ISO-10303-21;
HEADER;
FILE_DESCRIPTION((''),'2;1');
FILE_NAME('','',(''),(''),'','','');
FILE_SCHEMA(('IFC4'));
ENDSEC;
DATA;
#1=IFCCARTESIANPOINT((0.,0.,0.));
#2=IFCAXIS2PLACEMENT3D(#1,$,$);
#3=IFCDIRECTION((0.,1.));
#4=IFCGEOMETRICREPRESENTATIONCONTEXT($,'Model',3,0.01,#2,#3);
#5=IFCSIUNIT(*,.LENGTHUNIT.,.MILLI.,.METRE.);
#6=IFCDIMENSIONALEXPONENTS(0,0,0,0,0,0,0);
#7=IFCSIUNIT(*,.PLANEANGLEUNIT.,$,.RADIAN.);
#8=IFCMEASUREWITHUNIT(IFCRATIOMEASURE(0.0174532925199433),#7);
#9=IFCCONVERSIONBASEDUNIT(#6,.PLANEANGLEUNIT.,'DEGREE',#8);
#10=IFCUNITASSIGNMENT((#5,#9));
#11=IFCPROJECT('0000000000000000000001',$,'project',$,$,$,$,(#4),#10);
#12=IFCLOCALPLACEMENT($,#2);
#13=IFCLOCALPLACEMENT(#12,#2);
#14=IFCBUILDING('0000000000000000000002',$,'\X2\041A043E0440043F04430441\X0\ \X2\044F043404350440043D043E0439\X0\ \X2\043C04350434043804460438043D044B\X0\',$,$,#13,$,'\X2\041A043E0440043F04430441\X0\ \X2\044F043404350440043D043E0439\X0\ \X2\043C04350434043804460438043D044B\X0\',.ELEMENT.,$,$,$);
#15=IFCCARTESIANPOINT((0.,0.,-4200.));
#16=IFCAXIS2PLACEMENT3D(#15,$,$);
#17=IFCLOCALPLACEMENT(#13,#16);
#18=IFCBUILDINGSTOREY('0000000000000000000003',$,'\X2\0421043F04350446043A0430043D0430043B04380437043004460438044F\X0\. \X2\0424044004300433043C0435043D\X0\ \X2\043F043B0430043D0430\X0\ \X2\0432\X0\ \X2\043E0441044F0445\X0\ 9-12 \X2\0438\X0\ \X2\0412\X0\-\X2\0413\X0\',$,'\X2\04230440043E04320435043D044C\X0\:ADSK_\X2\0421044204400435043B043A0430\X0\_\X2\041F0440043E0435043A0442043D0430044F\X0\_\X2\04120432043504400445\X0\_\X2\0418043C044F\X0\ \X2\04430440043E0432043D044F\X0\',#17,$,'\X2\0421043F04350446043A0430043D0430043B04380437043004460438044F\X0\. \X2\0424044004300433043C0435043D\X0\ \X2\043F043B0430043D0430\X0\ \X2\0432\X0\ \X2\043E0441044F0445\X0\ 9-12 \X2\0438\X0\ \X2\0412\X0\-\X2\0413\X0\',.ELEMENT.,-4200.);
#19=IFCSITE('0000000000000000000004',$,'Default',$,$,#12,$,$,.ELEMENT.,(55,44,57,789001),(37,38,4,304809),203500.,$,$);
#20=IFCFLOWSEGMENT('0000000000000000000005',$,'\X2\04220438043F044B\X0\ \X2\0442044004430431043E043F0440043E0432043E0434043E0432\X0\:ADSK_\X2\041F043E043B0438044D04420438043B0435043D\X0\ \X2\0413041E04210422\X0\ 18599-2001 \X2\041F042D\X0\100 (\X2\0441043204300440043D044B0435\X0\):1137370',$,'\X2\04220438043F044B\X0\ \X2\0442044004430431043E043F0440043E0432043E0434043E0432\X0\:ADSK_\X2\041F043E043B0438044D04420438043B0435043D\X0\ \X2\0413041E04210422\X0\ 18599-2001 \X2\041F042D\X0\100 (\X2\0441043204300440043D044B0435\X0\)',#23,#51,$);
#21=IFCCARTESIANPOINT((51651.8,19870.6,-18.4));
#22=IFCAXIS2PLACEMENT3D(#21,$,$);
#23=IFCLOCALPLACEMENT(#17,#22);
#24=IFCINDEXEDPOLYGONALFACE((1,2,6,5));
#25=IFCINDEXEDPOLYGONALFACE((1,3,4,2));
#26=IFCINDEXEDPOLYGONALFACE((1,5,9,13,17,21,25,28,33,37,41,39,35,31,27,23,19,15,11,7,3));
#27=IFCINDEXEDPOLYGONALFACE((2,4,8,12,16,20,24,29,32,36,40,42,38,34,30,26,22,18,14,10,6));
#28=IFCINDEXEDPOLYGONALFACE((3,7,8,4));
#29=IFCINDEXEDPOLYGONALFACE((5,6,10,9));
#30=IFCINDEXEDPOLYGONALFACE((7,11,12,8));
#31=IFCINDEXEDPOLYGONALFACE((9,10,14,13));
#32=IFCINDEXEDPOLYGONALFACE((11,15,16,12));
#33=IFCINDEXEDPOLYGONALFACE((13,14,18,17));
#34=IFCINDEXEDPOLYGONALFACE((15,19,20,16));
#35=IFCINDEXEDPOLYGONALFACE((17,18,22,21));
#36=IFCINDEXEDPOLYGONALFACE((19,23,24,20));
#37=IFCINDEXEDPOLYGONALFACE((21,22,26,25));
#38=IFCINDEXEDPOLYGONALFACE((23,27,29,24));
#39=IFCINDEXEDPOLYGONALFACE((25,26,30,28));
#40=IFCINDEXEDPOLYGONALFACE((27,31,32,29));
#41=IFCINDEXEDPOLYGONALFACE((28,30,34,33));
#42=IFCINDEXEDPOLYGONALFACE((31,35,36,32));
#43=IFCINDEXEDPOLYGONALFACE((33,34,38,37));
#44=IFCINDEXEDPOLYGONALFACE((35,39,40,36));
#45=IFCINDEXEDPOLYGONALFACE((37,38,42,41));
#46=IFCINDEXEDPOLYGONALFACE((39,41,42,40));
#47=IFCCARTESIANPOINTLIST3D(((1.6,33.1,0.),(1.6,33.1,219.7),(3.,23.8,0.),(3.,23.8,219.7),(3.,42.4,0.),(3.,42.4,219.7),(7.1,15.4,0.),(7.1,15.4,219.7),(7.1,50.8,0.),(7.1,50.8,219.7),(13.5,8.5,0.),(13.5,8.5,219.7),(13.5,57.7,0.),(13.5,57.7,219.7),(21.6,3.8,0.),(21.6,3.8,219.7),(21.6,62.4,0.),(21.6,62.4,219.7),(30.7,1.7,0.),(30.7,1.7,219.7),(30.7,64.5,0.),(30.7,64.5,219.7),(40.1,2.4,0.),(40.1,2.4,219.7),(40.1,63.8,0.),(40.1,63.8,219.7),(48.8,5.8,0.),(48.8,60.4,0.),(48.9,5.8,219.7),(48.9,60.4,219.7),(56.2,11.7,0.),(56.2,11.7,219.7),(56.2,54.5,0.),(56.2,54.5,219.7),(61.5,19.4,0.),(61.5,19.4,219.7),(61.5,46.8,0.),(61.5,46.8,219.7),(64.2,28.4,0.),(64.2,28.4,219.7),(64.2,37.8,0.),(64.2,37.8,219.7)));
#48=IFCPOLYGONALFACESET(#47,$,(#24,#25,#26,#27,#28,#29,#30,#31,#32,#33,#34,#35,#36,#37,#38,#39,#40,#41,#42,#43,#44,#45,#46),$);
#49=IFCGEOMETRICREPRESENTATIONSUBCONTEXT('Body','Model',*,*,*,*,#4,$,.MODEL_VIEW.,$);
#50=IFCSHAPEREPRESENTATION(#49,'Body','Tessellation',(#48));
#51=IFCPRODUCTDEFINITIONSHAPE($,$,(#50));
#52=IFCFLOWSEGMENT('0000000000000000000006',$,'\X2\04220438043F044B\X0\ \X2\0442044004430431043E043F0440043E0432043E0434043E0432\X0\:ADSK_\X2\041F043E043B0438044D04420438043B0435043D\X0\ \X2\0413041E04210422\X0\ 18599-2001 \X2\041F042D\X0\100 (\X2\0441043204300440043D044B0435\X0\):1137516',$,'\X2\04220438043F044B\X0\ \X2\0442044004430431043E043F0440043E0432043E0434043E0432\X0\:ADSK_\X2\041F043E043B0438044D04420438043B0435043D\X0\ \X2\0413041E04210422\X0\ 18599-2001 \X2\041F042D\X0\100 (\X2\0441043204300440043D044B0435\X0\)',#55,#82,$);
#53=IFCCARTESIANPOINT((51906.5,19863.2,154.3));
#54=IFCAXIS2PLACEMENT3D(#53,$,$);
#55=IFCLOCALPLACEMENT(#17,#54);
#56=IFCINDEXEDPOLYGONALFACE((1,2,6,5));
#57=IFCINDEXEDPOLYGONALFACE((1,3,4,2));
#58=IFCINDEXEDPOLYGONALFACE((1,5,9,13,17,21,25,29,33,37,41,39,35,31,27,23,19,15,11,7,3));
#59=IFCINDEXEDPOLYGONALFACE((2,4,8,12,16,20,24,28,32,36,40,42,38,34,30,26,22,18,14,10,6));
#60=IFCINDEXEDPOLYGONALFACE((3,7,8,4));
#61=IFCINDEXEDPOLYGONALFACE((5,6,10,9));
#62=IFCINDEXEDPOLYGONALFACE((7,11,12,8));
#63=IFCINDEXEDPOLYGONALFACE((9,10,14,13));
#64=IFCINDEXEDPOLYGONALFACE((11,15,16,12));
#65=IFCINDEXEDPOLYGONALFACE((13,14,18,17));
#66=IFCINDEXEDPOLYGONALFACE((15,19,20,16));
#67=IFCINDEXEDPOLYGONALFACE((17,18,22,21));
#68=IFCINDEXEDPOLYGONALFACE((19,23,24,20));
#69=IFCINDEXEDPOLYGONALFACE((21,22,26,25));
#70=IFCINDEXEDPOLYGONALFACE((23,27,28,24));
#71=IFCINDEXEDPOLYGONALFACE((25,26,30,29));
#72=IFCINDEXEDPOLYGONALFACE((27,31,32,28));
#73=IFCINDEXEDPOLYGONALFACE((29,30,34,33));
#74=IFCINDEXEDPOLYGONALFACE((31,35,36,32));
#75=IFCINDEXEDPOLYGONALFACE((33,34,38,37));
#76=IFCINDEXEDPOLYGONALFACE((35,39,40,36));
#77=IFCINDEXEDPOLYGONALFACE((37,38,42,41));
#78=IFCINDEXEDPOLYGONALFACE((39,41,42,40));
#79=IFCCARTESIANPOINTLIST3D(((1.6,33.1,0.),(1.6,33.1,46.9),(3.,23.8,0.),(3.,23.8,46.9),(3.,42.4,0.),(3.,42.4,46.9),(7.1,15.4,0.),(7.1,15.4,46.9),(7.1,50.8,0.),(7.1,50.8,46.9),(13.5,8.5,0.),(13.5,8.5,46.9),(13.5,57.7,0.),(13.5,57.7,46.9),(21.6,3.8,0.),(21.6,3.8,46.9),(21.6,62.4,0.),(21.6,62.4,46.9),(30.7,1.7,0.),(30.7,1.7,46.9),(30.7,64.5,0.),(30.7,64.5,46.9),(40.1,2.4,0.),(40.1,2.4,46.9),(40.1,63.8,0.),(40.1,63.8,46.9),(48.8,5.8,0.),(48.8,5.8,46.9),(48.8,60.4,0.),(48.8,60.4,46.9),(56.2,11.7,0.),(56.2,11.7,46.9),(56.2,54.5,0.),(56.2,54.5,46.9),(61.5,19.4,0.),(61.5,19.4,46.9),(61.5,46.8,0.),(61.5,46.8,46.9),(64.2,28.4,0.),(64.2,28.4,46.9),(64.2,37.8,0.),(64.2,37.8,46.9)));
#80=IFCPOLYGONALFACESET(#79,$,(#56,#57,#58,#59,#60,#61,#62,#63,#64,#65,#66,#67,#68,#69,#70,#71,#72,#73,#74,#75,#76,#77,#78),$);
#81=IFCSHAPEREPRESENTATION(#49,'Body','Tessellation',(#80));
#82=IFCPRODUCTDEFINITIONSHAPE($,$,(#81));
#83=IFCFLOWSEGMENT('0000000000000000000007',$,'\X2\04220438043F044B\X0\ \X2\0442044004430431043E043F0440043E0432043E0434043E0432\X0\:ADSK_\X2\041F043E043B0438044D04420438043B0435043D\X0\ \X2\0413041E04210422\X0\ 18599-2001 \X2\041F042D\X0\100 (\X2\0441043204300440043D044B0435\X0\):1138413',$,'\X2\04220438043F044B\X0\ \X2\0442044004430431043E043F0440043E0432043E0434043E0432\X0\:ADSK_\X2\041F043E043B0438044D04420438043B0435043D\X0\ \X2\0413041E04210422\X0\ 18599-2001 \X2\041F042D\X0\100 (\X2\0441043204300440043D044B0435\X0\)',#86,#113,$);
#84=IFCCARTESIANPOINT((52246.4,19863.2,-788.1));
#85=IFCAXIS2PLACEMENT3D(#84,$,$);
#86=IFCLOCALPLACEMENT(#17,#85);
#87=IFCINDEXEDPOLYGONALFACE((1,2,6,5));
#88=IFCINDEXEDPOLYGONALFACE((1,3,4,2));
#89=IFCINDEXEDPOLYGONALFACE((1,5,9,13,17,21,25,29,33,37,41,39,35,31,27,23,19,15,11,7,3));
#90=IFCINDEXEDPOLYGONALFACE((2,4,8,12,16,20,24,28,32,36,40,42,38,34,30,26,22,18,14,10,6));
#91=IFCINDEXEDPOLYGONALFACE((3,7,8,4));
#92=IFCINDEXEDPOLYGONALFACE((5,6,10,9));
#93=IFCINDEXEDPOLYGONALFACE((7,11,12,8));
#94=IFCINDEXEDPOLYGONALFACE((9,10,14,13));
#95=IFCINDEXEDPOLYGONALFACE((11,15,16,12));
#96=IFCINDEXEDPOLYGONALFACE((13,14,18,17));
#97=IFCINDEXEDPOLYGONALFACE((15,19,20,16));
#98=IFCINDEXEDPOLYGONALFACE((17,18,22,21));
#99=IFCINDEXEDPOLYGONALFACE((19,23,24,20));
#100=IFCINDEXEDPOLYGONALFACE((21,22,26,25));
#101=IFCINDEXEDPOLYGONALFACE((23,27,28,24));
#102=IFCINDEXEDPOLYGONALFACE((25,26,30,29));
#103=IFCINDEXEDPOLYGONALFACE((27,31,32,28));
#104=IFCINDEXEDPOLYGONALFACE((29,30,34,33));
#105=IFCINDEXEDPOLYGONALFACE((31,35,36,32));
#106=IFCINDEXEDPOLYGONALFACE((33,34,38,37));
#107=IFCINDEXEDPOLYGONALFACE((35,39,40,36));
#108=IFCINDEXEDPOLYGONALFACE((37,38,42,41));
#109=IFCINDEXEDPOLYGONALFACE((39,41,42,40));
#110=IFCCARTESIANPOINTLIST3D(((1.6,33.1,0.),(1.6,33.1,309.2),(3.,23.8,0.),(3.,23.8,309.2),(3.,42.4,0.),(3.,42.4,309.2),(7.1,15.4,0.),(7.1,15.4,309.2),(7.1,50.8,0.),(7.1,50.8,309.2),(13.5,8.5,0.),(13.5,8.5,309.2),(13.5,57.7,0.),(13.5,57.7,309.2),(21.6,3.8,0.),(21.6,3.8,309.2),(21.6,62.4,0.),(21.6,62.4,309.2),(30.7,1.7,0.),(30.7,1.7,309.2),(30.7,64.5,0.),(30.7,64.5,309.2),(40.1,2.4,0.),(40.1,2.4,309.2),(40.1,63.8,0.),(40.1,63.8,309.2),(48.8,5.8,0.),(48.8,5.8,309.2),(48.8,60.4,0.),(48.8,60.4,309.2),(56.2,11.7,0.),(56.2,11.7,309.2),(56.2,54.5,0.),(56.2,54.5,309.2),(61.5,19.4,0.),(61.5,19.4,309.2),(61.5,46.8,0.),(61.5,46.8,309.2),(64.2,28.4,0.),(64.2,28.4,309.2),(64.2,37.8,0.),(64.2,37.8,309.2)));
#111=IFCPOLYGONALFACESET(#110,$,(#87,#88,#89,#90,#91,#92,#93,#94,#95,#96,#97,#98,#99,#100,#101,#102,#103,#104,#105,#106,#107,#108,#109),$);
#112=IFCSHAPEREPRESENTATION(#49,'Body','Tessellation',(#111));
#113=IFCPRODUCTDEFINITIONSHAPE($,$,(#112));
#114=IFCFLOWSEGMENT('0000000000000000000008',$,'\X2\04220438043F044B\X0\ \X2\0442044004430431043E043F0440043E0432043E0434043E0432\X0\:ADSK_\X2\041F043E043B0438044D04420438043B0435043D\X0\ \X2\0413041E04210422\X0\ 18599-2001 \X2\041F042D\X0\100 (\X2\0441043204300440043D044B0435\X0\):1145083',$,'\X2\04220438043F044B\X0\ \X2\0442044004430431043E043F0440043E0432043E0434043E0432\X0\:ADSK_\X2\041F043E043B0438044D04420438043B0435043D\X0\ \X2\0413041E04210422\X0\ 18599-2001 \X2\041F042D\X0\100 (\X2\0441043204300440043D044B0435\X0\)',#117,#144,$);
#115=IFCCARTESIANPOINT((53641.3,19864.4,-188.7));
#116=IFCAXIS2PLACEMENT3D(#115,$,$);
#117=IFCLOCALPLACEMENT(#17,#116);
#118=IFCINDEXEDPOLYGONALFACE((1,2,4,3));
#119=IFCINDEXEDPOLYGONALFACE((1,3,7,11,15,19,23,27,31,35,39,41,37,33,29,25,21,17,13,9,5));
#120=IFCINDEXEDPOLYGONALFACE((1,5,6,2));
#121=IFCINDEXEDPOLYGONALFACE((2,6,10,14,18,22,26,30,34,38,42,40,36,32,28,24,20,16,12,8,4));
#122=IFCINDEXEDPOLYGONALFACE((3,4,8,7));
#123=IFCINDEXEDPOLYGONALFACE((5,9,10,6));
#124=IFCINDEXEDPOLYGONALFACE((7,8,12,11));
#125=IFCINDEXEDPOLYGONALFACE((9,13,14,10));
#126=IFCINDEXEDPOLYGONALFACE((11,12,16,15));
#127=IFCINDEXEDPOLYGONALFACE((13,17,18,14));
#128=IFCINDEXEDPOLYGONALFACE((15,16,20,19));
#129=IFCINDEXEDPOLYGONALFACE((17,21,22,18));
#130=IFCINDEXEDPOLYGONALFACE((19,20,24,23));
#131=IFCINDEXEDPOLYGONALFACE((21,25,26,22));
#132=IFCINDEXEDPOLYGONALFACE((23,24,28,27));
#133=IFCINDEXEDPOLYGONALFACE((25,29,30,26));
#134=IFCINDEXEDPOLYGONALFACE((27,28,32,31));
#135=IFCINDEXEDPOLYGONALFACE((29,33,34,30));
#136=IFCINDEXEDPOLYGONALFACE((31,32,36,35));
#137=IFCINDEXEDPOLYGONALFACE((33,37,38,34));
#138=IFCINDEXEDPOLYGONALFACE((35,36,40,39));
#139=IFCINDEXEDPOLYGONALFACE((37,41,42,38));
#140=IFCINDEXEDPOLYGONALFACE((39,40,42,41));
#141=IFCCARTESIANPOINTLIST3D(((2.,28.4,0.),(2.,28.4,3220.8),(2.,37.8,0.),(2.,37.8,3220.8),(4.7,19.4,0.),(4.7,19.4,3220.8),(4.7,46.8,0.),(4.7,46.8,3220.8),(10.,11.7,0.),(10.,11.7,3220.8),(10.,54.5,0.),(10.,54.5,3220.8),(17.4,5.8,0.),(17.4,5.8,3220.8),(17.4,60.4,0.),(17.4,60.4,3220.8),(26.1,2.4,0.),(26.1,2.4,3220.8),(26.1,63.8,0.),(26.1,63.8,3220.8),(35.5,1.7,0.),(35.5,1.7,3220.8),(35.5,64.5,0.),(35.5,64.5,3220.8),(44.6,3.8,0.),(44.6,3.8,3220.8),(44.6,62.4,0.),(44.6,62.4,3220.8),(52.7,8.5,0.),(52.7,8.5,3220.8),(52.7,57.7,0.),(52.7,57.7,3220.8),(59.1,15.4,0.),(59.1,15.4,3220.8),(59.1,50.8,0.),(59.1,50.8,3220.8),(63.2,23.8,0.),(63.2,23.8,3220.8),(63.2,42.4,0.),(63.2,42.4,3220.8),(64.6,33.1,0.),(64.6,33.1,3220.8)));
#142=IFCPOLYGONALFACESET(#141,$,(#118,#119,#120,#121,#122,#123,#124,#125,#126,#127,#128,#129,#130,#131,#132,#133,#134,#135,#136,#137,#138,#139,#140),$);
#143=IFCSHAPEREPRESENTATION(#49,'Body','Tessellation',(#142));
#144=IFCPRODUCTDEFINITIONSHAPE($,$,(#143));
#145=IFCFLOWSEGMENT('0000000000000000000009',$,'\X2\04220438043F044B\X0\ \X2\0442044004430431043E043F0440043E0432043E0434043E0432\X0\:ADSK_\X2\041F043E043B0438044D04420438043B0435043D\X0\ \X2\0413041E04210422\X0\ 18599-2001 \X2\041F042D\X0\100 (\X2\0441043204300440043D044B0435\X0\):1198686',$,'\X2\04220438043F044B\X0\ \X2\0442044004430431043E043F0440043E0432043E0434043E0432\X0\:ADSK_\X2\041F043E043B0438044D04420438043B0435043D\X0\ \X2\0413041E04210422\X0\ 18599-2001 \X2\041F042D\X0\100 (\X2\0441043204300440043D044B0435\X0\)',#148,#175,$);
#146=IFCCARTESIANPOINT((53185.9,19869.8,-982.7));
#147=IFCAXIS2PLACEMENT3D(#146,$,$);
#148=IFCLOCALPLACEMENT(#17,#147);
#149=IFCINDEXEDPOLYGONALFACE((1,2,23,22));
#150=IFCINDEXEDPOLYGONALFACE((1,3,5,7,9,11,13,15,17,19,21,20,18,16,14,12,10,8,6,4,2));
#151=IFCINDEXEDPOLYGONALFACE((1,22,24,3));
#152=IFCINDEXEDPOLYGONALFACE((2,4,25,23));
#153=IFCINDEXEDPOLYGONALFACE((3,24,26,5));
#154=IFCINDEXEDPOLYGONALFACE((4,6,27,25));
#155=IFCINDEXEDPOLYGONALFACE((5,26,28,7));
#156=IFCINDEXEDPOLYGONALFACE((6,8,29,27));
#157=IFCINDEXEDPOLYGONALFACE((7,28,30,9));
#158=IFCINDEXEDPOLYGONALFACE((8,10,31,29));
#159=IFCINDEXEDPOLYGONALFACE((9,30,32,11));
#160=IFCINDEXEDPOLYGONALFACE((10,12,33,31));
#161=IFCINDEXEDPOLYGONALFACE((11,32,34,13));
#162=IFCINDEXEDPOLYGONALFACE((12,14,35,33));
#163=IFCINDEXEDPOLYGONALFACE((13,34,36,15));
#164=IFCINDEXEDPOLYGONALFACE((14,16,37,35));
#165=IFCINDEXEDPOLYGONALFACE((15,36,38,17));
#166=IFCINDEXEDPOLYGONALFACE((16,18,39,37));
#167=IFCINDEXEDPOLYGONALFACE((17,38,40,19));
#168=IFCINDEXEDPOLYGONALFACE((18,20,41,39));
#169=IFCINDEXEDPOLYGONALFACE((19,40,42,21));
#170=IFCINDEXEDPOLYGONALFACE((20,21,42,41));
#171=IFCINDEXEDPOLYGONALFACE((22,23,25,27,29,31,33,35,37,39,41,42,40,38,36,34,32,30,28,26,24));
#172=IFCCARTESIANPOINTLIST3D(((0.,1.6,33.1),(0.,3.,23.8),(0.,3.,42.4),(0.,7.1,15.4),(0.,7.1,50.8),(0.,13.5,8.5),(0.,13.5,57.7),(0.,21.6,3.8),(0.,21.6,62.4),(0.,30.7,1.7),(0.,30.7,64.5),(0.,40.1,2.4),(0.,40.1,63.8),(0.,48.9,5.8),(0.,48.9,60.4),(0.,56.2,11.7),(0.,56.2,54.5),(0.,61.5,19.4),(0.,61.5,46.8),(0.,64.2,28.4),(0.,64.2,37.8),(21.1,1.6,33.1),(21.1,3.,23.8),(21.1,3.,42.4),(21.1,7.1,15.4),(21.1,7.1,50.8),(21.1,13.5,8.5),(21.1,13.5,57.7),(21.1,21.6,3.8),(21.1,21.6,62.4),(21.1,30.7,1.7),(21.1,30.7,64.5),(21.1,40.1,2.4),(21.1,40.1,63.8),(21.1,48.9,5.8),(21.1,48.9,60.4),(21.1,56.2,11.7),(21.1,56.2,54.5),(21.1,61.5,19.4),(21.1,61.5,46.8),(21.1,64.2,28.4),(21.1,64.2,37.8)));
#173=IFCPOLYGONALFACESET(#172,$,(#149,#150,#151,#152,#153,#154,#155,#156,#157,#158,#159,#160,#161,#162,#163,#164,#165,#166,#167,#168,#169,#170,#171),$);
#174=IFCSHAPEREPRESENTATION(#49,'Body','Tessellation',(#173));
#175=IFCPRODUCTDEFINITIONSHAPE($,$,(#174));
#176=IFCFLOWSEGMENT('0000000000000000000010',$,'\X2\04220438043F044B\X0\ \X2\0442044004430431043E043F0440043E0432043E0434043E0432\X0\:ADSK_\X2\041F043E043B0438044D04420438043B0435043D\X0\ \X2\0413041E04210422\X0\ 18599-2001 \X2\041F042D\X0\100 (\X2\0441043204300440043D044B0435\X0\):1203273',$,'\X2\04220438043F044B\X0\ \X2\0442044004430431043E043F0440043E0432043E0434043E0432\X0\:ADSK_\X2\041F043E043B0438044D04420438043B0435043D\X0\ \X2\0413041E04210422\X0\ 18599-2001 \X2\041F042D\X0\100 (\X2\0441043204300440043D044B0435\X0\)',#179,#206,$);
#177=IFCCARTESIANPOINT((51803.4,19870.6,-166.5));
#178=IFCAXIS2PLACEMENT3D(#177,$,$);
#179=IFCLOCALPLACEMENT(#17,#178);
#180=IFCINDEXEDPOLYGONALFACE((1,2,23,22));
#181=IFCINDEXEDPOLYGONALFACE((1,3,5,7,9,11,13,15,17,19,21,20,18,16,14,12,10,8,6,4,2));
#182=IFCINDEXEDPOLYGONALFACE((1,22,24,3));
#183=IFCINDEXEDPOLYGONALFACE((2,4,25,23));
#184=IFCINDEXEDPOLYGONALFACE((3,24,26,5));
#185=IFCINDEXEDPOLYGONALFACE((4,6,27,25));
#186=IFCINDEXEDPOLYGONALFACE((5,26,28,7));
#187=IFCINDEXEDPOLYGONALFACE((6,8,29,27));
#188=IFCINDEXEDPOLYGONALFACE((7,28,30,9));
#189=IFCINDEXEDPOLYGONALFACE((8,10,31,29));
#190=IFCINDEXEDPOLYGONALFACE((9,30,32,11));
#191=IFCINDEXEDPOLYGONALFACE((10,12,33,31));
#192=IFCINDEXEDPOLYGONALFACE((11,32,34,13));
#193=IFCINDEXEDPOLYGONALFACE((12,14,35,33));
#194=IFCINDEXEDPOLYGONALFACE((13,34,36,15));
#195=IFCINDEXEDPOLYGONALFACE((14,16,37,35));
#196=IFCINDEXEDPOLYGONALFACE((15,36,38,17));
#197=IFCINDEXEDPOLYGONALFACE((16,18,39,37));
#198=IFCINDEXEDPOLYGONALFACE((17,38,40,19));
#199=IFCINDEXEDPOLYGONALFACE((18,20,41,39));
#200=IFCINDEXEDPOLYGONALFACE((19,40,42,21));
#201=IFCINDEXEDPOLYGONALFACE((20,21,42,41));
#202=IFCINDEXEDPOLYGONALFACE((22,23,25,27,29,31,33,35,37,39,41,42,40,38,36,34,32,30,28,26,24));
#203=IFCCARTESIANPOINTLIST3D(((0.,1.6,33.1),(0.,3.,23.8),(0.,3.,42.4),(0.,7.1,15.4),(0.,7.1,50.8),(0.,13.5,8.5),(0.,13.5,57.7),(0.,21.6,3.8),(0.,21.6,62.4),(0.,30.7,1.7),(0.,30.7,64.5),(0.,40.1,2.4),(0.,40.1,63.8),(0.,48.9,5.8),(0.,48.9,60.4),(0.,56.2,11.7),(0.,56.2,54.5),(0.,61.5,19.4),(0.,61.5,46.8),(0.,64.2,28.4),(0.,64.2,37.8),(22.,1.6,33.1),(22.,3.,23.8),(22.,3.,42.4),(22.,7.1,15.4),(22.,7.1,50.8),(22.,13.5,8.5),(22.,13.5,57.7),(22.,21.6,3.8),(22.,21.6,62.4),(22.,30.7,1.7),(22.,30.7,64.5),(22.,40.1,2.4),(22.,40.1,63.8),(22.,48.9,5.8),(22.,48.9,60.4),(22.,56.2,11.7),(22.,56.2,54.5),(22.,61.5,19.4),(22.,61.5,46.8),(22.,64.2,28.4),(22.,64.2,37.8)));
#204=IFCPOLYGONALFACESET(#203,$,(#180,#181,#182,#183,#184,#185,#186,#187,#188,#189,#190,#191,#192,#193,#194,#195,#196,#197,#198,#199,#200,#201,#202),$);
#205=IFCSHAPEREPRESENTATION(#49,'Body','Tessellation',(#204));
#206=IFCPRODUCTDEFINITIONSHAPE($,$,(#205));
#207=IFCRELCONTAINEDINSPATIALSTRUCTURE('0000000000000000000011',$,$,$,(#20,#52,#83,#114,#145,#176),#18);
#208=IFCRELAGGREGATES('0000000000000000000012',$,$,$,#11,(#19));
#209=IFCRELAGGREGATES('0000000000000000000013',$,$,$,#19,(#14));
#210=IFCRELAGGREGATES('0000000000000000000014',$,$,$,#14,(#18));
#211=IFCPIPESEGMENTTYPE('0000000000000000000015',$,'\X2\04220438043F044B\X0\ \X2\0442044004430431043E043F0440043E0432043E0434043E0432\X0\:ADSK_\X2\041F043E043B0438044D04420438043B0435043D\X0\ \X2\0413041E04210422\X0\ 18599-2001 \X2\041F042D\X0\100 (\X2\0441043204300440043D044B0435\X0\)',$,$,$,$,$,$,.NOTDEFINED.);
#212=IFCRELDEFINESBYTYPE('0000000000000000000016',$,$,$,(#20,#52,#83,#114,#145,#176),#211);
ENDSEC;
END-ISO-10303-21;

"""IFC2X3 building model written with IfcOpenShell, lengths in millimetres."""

from ifc_helpers import new_model, entity, si_unit, converted_unit, direction, frame, origin, origin_2d_with_axis, place, context, subcontext, project, spatial, circle, extrude, type_object, element, save


model = new_model("IFC2X3")

# Units and contexts
model_context = context("Model", 3, precision=0.01, world=origin(), true_north=direction((0.0, 1.0)))
body_context = subcontext(model_context, "Body", "Model", "MODEL_VIEW")
ifc_project = project(units=[si_unit("LENGTHUNIT", "METRE", prefix="MILLI"), converted_unit("PLANEANGLEUNIT", "DEGREE", entity("IfcRatioMeasure", 0.0174532925199433), si_unit("PLANEANGLEUNIT", "RADIAN"), dimensions=[0, 0, 0, 0, 0, 0, 0])], contexts=[model_context])

# Site, building, storey
site_placement = place(None, origin())
site = spatial("IfcSite", under=ifc_project, at=site_placement, Name="Default", CompositionType="ELEMENT", RefLatitude=(55, 44, 57, 789001), RefLongitude=(37, 38, 4, 304809), RefElevation=203500.0)
building_placement = place(site_placement, origin())
building = spatial("IfcBuilding", under=site, at=building_placement, Name="Корпус ядерной медицины", LongName="Корпус ядерной медицины", CompositionType="ELEMENT")
storey_placement = place(building_placement, frame((0.0, 0.0, -4200.0)))
storey = spatial("IfcBuildingStorey", under=building, at=storey_placement, Name="Спецканализация. Фрагмен плана в осях 9-12 и В-Г", ObjectType="Уровень:ADSK_Стрелка_Проектная_Вверх_Имя уровня", LongName="Спецканализация. Фрагмен плана в осях 9-12 и В-Г", CompositionType="ELEMENT", Elevation=-4200.0)

# Flow segments
pipe_segment_type = type_object("IfcPipeSegmentType", Name="Типы трубопроводов:ADSK_Полиэтилен ГОСТ 18599-2001 ПЭ100 (сварные)", PredefinedType="NOTDEFINED")
flow_segment_1_placement = place(storey_placement, frame((51651.8, 19870.6, -18.4)))
element("IfcFlowSegment", 1, at=flow_segment_1_placement, inside=storey, type_object=pipe_segment_type, Name="Типы трубопроводов:ADSK_Полиэтилен ГОСТ 18599-2001 ПЭ100 (сварные):1137370", ObjectType="Типы трубопроводов:ADSK_Полиэтилен ГОСТ 18599-2001 ПЭ100 (сварные)", context=body_context, shape_type="SweptSolid", body=[
    extrude(circle(Radius=31.5, at=origin_2d_with_axis()), frame((33.1, 33.1, 0.0), z_axis=(0.0, 0.0, 1.0), x_axis=(-1.0, 0.0, 0.0)), (0.0, 0.0, 1.0), 219.7),
])
flow_segment_2_placement = place(storey_placement, frame((51906.5, 19863.2, 154.3)))
element("IfcFlowSegment", 2, at=flow_segment_2_placement, inside=storey, type_object=pipe_segment_type, Name="Типы трубопроводов:ADSK_Полиэтилен ГОСТ 18599-2001 ПЭ100 (сварные):1137516", ObjectType="Типы трубопроводов:ADSK_Полиэтилен ГОСТ 18599-2001 ПЭ100 (сварные)", context=body_context, shape_type="SweptSolid", body=[
    extrude(circle(Radius=31.5, at=origin_2d_with_axis()), frame((33.1, 33.1, 0.0), z_axis=(0.0, 0.0, 1.0), x_axis=(-1.0, 0.0, 0.0)), (0.0, 0.0, 1.0), 46.9),
])
flow_segment_3_placement = place(storey_placement, frame((52246.4, 19863.2, -788.1)))
element("IfcFlowSegment", 3, at=flow_segment_3_placement, inside=storey, type_object=pipe_segment_type, Name="Типы трубопроводов:ADSK_Полиэтилен ГОСТ 18599-2001 ПЭ100 (сварные):1138413", ObjectType="Типы трубопроводов:ADSK_Полиэтилен ГОСТ 18599-2001 ПЭ100 (сварные)", context=body_context, shape_type="SweptSolid", body=[
    extrude(circle(Radius=31.5, at=origin_2d_with_axis()), frame((33.1, 33.1, 0.0), z_axis=(0.0, 0.0, 1.0), x_axis=(-1.0, 0.0, 0.0)), (0.0, 0.0, 1.0), 309.2),
])
flow_segment_4_placement = place(storey_placement, frame((53641.3, 19864.4, -188.7)))
element("IfcFlowSegment", 4, at=flow_segment_4_placement, inside=storey, type_object=pipe_segment_type, Name="Типы трубопроводов:ADSK_Полиэтилен ГОСТ 18599-2001 ПЭ100 (сварные):1145083", ObjectType="Типы трубопроводов:ADSK_Полиэтилен ГОСТ 18599-2001 ПЭ100 (сварные)", context=body_context, shape_type="SweptSolid", body=[
    extrude(circle(Radius=31.5, at=origin_2d_with_axis()), frame((33.1, 33.1, 0.0)), (0.0, 0.0, 1.0), 3220.8),
])
flow_segment_5_placement = place(storey_placement, frame((53185.9, 19869.8, -982.7)))
element("IfcFlowSegment", 5, at=flow_segment_5_placement, inside=storey, type_object=pipe_segment_type, Name="Типы трубопроводов:ADSK_Полиэтилен ГОСТ 18599-2001 ПЭ100 (сварные):1198686", ObjectType="Типы трубопроводов:ADSK_Полиэтилен ГОСТ 18599-2001 ПЭ100 (сварные)", context=body_context, shape_type="SweptSolid", body=[
    extrude(circle(Radius=31.5, at=origin_2d_with_axis()), frame((0.0, 33.1, 33.1), z_axis=(1.0, 0.0, 0.0), x_axis=(0.0, -1.0, 0.0)), (0.0, 0.0, 1.0), 21.1),
])
flow_segment_6_placement = place(storey_placement, frame((51803.4, 19870.6, -166.5)))
element("IfcFlowSegment", 6, at=flow_segment_6_placement, inside=storey, type_object=pipe_segment_type, Name="Типы трубопроводов:ADSK_Полиэтилен ГОСТ 18599-2001 ПЭ100 (сварные):1203273", ObjectType="Типы трубопроводов:ADSK_Полиэтилен ГОСТ 18599-2001 ПЭ100 (сварные)", context=body_context, shape_type="SweptSolid", body=[
    extrude(circle(Radius=31.5, at=origin_2d_with_axis()), frame((0.0, 33.1, 33.1), z_axis=(1.0, 0.0, 0.0), x_axis=(0.0, -1.0, 0.0)), (0.0, 0.0, 1.0), 22.0),
])

save(model, "model.ifc")
